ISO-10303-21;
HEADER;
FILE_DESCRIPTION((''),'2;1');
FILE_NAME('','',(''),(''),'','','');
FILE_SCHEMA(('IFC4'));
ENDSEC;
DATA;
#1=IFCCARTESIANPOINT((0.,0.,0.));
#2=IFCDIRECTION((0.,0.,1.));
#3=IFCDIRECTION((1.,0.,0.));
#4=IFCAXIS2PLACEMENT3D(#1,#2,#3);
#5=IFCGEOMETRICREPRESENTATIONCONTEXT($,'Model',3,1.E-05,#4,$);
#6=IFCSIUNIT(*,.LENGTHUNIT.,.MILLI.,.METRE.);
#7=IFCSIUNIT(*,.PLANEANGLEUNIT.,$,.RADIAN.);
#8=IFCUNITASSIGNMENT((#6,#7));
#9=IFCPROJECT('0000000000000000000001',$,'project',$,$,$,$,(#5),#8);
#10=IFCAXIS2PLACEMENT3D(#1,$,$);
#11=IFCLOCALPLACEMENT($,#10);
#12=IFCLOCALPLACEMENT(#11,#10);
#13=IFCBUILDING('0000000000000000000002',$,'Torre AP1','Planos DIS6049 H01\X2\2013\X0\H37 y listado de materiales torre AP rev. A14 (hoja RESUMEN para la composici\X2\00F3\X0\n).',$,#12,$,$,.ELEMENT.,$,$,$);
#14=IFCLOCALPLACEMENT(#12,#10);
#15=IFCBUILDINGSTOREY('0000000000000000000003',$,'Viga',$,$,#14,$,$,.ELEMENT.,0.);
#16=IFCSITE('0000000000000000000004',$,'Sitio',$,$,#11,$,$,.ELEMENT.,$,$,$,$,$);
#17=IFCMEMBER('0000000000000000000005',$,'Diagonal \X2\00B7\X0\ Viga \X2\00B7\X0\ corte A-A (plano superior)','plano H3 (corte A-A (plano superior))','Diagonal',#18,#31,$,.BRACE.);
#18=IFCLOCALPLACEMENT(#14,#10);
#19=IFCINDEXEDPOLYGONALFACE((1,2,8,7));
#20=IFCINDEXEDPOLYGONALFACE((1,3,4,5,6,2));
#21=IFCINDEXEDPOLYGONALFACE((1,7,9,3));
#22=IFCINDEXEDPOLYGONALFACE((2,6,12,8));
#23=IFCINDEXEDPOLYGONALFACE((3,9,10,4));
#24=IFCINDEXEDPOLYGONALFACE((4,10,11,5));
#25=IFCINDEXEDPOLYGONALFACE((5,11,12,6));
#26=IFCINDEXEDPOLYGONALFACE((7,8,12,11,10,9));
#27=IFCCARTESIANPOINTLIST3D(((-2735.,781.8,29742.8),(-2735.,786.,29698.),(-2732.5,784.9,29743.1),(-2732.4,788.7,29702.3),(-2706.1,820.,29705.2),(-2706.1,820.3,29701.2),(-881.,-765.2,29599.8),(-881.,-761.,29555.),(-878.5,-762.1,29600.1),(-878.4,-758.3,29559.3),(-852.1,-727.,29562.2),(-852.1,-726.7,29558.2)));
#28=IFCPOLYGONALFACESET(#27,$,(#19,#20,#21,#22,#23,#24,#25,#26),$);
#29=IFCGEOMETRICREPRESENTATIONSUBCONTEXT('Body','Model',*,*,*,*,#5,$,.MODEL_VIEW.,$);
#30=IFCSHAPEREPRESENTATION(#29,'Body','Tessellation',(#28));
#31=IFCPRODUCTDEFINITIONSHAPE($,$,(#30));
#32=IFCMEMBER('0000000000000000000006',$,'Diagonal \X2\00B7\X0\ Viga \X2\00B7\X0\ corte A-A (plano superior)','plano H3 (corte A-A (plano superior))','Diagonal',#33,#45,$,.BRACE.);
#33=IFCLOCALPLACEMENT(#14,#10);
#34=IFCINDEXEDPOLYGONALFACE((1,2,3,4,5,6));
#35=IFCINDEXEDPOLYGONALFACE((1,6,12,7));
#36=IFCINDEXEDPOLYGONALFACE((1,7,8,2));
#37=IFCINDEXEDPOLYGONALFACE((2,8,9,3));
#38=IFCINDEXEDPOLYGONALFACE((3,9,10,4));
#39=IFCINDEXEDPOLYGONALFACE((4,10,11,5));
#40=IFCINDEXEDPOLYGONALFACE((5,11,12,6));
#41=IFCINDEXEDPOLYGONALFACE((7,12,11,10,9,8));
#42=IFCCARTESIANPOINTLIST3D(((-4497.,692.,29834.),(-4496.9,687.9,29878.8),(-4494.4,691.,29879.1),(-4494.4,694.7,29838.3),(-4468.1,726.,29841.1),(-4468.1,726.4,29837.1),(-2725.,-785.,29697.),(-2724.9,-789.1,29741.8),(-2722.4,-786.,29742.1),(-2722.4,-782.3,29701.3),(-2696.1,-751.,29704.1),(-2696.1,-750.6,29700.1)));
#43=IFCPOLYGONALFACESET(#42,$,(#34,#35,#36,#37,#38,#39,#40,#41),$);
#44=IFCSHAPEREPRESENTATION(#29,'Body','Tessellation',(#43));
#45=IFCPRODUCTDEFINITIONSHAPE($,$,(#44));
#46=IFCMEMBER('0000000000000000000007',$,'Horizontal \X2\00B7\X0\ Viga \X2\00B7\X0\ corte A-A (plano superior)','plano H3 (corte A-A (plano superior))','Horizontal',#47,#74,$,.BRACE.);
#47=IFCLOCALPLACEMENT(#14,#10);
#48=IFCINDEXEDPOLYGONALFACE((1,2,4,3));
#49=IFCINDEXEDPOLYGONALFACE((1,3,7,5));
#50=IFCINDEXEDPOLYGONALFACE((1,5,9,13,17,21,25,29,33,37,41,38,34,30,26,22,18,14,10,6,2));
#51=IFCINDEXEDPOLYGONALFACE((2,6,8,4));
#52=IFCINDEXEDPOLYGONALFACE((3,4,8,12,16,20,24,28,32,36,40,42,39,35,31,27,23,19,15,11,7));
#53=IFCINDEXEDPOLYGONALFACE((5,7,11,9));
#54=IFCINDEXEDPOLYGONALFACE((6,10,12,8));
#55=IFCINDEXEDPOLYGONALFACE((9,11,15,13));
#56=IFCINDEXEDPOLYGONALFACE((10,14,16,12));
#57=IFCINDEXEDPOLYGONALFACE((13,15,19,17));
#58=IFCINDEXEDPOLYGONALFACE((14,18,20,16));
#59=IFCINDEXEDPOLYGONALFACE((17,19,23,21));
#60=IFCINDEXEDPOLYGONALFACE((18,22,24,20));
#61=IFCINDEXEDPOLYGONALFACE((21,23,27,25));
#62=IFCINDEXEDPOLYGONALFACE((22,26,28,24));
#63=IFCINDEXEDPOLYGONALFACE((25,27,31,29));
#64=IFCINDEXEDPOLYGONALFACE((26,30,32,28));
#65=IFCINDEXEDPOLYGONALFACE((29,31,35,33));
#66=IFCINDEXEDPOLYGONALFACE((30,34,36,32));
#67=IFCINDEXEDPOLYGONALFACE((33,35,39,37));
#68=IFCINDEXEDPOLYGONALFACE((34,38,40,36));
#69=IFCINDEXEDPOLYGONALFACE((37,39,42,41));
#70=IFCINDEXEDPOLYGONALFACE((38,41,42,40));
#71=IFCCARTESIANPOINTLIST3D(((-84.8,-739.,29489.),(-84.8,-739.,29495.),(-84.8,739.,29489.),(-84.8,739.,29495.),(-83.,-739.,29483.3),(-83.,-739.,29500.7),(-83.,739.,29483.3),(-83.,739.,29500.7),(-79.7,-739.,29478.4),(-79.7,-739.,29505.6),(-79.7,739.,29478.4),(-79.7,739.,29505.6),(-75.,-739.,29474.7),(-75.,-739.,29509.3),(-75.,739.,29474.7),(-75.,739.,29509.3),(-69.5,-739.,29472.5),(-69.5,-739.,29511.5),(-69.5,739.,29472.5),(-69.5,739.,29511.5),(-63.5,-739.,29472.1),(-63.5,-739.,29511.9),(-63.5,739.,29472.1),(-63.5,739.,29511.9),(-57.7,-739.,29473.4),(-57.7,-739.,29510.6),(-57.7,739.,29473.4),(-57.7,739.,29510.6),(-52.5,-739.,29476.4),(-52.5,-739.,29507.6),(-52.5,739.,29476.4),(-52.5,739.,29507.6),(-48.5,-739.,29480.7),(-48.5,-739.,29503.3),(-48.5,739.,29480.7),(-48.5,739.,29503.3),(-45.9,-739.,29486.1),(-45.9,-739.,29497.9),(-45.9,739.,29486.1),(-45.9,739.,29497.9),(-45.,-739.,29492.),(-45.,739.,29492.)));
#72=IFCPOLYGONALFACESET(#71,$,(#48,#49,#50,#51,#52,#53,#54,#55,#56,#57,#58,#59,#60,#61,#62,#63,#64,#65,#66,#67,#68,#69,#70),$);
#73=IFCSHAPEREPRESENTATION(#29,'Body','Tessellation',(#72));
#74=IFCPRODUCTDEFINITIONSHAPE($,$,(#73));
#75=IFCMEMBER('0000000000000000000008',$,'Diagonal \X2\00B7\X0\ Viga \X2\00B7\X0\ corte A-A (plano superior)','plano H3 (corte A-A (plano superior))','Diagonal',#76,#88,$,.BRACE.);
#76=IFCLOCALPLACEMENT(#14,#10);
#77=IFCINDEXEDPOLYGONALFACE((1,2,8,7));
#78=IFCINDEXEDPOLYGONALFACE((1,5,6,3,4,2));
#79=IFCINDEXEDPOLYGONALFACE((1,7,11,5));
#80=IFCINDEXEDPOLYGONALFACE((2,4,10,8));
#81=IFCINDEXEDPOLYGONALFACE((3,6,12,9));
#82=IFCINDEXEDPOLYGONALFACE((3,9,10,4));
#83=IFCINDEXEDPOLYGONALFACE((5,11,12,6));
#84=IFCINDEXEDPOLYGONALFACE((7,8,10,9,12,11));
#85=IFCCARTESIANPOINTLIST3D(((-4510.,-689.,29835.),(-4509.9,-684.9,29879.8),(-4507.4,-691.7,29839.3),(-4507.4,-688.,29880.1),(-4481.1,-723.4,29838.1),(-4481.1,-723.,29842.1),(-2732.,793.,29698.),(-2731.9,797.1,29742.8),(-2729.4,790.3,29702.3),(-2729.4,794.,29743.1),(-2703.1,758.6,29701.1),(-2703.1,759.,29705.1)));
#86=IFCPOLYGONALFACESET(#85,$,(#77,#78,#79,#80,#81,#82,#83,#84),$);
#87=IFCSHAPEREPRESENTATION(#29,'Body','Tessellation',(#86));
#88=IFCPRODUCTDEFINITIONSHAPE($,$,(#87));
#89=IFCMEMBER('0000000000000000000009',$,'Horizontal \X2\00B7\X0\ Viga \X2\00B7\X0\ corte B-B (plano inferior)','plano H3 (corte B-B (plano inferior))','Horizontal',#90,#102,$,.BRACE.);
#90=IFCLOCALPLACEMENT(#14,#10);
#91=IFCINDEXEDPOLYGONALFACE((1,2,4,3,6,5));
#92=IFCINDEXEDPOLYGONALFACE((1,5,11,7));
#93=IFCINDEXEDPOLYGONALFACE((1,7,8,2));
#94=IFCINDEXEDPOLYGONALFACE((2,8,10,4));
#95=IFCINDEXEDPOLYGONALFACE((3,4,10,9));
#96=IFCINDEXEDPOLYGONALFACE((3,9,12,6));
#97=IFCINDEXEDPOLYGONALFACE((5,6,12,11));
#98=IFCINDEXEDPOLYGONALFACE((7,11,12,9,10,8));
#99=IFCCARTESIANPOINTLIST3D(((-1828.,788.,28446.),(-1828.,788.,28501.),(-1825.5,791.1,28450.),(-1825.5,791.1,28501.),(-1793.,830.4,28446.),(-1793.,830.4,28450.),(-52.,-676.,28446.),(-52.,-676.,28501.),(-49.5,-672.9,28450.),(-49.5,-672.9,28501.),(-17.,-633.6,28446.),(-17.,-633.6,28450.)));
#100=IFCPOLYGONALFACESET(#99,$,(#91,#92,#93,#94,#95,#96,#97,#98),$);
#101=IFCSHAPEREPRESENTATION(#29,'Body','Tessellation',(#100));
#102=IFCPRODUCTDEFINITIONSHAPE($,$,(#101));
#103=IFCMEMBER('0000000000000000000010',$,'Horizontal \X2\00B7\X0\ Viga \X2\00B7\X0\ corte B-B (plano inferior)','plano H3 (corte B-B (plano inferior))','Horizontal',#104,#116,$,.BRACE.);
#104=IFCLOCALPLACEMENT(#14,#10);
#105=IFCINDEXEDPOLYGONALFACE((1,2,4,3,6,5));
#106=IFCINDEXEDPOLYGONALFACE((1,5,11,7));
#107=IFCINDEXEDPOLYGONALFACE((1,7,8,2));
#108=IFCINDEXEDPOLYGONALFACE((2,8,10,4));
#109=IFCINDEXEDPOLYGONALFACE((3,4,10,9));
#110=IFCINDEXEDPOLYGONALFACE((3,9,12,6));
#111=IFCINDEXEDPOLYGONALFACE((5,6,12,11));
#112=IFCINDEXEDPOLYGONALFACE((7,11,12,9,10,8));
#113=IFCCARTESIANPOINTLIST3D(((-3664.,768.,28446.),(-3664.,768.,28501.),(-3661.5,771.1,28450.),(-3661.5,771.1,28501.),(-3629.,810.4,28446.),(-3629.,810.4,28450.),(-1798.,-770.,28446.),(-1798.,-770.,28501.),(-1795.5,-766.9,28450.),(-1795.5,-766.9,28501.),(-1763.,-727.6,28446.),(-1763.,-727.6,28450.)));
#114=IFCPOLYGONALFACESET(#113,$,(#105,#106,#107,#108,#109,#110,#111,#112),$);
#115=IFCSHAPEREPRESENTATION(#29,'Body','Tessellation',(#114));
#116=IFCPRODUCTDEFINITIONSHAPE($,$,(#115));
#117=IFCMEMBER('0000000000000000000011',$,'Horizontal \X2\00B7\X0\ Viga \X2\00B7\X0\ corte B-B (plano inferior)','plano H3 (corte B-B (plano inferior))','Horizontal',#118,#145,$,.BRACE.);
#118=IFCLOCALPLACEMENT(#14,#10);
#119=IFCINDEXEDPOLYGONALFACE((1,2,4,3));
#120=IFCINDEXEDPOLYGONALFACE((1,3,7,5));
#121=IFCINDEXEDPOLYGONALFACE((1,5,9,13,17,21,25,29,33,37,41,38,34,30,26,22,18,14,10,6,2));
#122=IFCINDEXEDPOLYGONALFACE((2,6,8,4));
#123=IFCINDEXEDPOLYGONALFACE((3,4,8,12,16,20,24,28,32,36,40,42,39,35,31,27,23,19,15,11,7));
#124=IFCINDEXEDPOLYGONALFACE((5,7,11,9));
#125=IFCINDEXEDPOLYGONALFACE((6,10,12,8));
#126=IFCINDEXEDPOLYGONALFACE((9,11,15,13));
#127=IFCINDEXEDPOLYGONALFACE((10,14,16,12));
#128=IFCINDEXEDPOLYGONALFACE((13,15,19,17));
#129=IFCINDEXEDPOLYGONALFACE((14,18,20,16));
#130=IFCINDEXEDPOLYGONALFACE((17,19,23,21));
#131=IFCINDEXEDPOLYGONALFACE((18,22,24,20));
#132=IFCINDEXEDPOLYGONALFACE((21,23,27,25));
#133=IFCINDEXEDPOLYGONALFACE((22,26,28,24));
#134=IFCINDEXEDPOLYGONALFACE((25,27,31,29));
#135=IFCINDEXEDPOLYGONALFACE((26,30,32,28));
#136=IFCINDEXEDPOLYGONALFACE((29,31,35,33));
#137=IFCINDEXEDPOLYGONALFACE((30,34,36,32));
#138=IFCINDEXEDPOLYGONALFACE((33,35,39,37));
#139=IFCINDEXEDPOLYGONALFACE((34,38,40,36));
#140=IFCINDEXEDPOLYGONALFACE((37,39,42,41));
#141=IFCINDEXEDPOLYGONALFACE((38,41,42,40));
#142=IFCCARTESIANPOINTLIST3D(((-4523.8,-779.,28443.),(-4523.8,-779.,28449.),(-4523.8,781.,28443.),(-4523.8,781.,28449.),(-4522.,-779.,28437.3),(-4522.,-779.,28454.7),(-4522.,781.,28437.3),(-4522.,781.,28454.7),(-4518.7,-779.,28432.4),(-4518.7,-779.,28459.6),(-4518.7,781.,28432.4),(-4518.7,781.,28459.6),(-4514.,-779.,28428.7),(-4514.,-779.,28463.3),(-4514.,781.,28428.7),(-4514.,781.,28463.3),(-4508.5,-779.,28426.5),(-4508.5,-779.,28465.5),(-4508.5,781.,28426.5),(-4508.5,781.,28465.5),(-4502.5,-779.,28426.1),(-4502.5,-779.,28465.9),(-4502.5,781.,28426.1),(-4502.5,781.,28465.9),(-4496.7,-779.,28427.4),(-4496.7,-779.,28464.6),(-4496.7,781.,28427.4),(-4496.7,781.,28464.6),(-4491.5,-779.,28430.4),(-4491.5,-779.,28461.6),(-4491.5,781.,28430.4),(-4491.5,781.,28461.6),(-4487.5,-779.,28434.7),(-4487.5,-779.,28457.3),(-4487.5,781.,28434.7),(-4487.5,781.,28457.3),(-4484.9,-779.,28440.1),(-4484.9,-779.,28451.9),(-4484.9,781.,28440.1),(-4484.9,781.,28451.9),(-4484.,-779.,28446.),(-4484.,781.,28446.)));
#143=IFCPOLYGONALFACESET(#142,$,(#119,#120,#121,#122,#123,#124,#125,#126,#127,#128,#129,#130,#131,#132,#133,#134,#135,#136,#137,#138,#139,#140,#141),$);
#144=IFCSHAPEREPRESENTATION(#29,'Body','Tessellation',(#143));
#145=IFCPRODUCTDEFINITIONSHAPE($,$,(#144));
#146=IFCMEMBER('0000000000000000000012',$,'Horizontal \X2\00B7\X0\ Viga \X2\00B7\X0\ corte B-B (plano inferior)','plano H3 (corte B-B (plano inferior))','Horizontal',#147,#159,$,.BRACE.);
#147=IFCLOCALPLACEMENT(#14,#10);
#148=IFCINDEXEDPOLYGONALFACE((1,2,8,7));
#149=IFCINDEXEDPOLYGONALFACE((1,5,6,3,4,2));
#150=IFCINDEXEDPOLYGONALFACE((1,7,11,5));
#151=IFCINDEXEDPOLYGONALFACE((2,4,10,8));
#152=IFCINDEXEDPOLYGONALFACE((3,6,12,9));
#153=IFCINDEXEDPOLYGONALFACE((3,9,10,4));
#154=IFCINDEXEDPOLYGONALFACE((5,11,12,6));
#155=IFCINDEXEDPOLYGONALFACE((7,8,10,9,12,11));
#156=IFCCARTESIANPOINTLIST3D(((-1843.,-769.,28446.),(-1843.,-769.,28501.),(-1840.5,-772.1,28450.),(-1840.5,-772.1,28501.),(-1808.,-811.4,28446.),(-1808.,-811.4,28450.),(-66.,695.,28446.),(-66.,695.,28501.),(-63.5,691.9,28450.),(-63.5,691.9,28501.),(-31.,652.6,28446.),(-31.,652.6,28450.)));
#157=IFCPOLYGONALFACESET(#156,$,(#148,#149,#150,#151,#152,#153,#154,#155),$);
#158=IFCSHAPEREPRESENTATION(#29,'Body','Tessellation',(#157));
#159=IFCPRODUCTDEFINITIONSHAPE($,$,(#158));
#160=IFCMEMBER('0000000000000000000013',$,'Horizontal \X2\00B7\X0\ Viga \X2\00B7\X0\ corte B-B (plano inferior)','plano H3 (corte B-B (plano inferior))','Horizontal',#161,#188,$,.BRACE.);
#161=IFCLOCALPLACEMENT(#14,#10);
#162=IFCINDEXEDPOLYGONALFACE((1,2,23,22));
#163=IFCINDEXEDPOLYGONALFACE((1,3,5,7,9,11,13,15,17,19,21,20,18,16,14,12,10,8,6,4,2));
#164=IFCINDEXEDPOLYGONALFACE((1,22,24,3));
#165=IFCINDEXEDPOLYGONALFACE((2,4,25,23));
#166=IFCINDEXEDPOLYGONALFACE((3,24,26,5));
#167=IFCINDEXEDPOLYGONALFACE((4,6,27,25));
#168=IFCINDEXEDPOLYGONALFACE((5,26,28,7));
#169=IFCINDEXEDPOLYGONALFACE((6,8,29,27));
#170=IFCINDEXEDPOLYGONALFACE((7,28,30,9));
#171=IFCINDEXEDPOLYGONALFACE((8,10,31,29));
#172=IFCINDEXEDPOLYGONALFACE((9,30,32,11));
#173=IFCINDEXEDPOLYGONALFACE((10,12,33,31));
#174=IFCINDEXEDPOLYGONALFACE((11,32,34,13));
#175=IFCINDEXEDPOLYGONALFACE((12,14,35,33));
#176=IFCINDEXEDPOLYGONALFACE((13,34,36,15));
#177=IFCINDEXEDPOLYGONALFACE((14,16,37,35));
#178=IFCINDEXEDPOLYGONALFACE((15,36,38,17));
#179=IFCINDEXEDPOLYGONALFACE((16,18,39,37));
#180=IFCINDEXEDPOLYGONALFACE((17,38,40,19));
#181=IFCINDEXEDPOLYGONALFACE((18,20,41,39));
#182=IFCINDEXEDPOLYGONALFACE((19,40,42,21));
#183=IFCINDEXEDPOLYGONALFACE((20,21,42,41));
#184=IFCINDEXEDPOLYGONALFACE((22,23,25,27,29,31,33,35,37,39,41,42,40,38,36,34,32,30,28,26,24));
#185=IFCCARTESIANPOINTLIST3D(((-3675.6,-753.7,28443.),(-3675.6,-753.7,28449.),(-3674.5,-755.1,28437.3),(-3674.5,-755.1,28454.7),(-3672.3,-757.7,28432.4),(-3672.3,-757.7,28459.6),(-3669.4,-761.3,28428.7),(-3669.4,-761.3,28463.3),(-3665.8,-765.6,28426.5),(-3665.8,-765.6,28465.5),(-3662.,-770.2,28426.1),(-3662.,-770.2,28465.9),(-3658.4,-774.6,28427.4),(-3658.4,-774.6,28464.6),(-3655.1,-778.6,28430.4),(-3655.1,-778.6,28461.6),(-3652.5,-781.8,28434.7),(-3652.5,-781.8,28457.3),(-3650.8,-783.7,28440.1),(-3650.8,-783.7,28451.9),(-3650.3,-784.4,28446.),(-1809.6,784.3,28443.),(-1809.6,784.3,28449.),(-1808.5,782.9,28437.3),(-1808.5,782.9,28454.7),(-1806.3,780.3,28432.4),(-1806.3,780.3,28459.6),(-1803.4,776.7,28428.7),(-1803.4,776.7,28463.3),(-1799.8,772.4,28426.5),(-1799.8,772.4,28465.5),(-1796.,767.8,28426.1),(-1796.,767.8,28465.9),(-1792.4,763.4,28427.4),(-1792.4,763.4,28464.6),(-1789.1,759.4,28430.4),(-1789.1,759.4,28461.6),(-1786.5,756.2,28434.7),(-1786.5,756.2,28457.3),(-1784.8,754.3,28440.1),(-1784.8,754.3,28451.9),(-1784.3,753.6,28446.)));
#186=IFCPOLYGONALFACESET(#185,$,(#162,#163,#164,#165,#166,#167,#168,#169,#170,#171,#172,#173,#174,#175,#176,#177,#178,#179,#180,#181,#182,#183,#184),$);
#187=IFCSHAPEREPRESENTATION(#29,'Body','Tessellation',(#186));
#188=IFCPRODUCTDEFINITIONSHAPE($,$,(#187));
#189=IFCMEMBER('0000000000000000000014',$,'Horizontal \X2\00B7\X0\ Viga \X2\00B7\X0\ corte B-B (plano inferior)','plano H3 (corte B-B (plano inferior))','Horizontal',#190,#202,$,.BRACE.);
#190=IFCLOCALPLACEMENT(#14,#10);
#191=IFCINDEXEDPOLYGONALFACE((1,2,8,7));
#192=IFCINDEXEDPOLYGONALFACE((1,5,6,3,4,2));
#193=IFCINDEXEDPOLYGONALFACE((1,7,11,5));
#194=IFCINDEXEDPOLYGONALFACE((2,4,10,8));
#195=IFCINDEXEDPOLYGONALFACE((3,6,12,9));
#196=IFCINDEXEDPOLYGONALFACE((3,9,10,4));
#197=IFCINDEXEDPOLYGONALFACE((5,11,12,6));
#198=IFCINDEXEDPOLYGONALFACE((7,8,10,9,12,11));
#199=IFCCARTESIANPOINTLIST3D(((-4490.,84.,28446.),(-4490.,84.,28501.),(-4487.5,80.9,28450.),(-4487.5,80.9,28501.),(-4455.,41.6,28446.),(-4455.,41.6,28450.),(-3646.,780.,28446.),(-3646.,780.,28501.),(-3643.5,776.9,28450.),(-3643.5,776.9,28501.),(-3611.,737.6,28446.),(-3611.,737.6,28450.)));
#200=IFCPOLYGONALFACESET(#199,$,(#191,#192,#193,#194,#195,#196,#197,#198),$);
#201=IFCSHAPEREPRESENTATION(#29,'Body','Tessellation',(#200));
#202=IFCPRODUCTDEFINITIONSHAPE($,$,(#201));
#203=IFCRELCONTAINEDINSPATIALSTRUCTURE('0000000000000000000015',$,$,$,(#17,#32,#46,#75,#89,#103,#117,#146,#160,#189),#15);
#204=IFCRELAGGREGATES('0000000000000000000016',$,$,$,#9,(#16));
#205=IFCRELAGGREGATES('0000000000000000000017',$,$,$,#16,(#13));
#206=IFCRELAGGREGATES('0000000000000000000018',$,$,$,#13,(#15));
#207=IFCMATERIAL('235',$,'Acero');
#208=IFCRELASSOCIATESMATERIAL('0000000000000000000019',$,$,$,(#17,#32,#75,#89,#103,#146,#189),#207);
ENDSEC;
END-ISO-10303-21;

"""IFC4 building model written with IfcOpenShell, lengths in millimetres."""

from ifc_helpers import new_model, si_unit, frame, frame_2d, origin, origin_with_axes, place, context, subcontext, project, spatial, circle, l_section, extrude, material, element, save


model = new_model("IFC4")

# Units and contexts
model_context = context("Model", 3, precision=1e-05, world=origin_with_axes())
body_context = subcontext(model_context, "Body", "Model", "MODEL_VIEW")
ifc_project = project(units=[si_unit("LENGTHUNIT", "METRE", prefix="MILLI"), si_unit("PLANEANGLEUNIT", "RADIAN")], contexts=[model_context])

# Site, building, storey
site_placement = place(None, origin())
site = spatial("IfcSite", under=ifc_project, at=site_placement, Name="Sitio", CompositionType="ELEMENT")
building_placement = place(site_placement, origin())
building = spatial("IfcBuilding", under=site, at=building_placement, Name="Torre AP1", Description="Planos DIS6049 H01–H37 y listado de materiales torre AP rev. A14 (hoja RESUMEN para la composición).", CompositionType="ELEMENT")
storey_placement = place(building_placement, origin())
storey = spatial("IfcBuildingStorey", under=building, at=storey_placement, Name="Viga", CompositionType="ELEMENT", Elevation=0.0)

# Members
ifc_material = material(Name="235", Category="Acero")
member_1_placement = place(storey_placement, frame((-2735.0, 786.0, 29698.0), z_axis=(0.766471, -0.639553, -0.059118), x_axis=(0.642279, 0.763125, 0.071544)))
element("IfcMember", 1, at=member_1_placement, inside=storey, material=ifc_material, Name="Diagonal · Viga · corte A-A (plano superior)", Description="plano H3 (corte A-A (plano superior))", ObjectType="Diagonal", PredefinedType="BRACE", context=body_context, shape_type="SweptSolid", body=[
    extrude(l_section(Depth=45.0, Width=45.0, Thickness=4.0, at=frame_2d((22.5, 22.5))), None, (0.0, 0.0, 1.0), 2418.9),
])
member_2_placement = place(storey_placement, frame((-4497.0, 692.0, 29834.0), z_axis=(0.766799, -0.639144, -0.059284), x_axis=(0.641886, 0.763689, 0.069004)))
element("IfcMember", 2, at=member_2_placement, inside=storey, material=ifc_material, Name="Diagonal · Viga · corte A-A (plano superior)", Description="plano H3 (corte A-A (plano superior))", ObjectType="Diagonal", PredefinedType="BRACE", context=body_context, shape_type="SweptSolid", body=[
    extrude(l_section(Depth=45.0, Width=45.0, Thickness=4.0, at=frame_2d((22.5, 22.5))), None, (0.0, 0.0, 1.0), 2310.9),
])
member_3_placement = place(storey_placement, frame((-65.0, 739.0, 29492.0), z_axis=(0.0, -1.0, 0.0), x_axis=(1.0, 0.0, 0.0)))
element("IfcMember", 3, at=member_3_placement, inside=storey, Name="Horizontal · Viga · corte A-A (plano superior)", Description="plano H3 (corte A-A (plano superior))", ObjectType="Horizontal", PredefinedType="BRACE", context=body_context, shape_type="SweptSolid", body=[
    extrude(circle(Radius=20.0), None, (0.0, 0.0, 1.0), 1478.0),
])
member_4_placement = place(storey_placement, frame((-2732.0, 793.0, 29698.0), z_axis=(-0.766808, -0.639151, 0.059085), x_axis=(0.641875, -0.763738, 0.068568)))
element("IfcMember", 4, at=member_4_placement, inside=storey, material=ifc_material, Name="Diagonal · Viga · corte A-A (plano superior)", Description="plano H3 (corte A-A (plano superior))", ObjectType="Diagonal", PredefinedType="BRACE", context=body_context, shape_type="SweptSolid", body=[
    extrude(l_section(Depth=45.0, Width=45.0, Thickness=4.0, at=frame_2d((22.5, 22.5))), None, (0.0, 0.0, 1.0), 2318.7),
])
member_5_placement = place(storey_placement, frame((-1828.0, 788.0, 28446.0), z_axis=(0.771629, -0.636073, 0.0), x_axis=(0.636073, 0.771629, 0.0)))
element("IfcMember", 5, at=member_5_placement, inside=storey, material=ifc_material, Name="Horizontal · Viga · corte B-B (plano inferior)", Description="plano H3 (corte B-B (plano inferior))", ObjectType="Horizontal", PredefinedType="BRACE", context=body_context, shape_type="SweptSolid", body=[
    extrude(l_section(Depth=55.0, Width=55.0, Thickness=4.0, at=frame_2d((27.5, 27.5))), None, (0.0, 0.0, 1.0), 2301.6),
])
member_6_placement = place(storey_placement, frame((-3664.0, 768.0, 28446.0), z_axis=(0.771668, -0.636026, 0.0), x_axis=(0.636026, 0.771668, 0.0)))
element("IfcMember", 6, at=member_6_placement, inside=storey, material=ifc_material, Name="Horizontal · Viga · corte B-B (plano inferior)", Description="plano H3 (corte B-B (plano inferior))", ObjectType="Horizontal", PredefinedType="BRACE", context=body_context, shape_type="SweptSolid", body=[
    extrude(l_section(Depth=55.0, Width=55.0, Thickness=4.0, at=frame_2d((27.5, 27.5))), None, (0.0, 0.0, 1.0), 2418.1),
])
member_7_placement = place(storey_placement, frame((-4504.0, 781.0, 28446.0), z_axis=(0.0, -1.0, 0.0), x_axis=(1.0, 0.0, 0.0)))
element("IfcMember", 7, at=member_7_placement, inside=storey, Name="Horizontal · Viga · corte B-B (plano inferior)", Description="plano H3 (corte B-B (plano inferior))", ObjectType="Horizontal", PredefinedType="BRACE", context=body_context, shape_type="SweptSolid", body=[
    extrude(circle(Radius=20.0), None, (0.0, 0.0, 1.0), 1560.0),
])
member_8_placement = place(storey_placement, frame((-66.0, 695.0, 28446.0), z_axis=(-0.771805, -0.635859, 0.0), x_axis=(0.635859, -0.771805, 0.0)))
element("IfcMember", 8, at=member_8_placement, inside=storey, material=ifc_material, Name="Horizontal · Viga · corte B-B (plano inferior)", Description="plano H3 (corte B-B (plano inferior))", ObjectType="Horizontal", PredefinedType="BRACE", context=body_context, shape_type="SweptSolid", body=[
    extrude(l_section(Depth=55.0, Width=55.0, Thickness=4.0, at=frame_2d((27.5, 27.5))), None, (0.0, 0.0, 1.0), 2302.4),
])
member_9_placement = place(storey_placement, frame((-1797.0, 769.0, 28446.0), z_axis=(-0.771668, -0.636026, 0.0), x_axis=(0.636026, -0.771668, 0.0)))
element("IfcMember", 9, at=member_9_placement, inside=storey, Name="Horizontal · Viga · corte B-B (plano inferior)", Description="plano H3 (corte B-B (plano inferior))", ObjectType="Horizontal", PredefinedType="BRACE", context=body_context, shape_type="SweptSolid", body=[
    extrude(circle(Radius=20.0), None, (0.0, 0.0, 1.0), 2418.1),
])
member_10_placement = place(storey_placement, frame((-3646.0, 780.0, 28446.0), z_axis=(-0.771508, -0.63622, 0.0), x_axis=(0.63622, -0.771508, 0.0)))
element("IfcMember", 10, at=member_10_placement, inside=storey, material=ifc_material, Name="Horizontal · Viga · corte B-B (plano inferior)", Description="plano H3 (corte B-B (plano inferior))", ObjectType="Horizontal", PredefinedType="BRACE", context=body_context, shape_type="SweptSolid", body=[
    extrude(l_section(Depth=55.0, Width=55.0, Thickness=4.0, at=frame_2d((27.5, 27.5))), None, (0.0, 0.0, 1.0), 1094.0),
])

save(model, "model.ifc")
